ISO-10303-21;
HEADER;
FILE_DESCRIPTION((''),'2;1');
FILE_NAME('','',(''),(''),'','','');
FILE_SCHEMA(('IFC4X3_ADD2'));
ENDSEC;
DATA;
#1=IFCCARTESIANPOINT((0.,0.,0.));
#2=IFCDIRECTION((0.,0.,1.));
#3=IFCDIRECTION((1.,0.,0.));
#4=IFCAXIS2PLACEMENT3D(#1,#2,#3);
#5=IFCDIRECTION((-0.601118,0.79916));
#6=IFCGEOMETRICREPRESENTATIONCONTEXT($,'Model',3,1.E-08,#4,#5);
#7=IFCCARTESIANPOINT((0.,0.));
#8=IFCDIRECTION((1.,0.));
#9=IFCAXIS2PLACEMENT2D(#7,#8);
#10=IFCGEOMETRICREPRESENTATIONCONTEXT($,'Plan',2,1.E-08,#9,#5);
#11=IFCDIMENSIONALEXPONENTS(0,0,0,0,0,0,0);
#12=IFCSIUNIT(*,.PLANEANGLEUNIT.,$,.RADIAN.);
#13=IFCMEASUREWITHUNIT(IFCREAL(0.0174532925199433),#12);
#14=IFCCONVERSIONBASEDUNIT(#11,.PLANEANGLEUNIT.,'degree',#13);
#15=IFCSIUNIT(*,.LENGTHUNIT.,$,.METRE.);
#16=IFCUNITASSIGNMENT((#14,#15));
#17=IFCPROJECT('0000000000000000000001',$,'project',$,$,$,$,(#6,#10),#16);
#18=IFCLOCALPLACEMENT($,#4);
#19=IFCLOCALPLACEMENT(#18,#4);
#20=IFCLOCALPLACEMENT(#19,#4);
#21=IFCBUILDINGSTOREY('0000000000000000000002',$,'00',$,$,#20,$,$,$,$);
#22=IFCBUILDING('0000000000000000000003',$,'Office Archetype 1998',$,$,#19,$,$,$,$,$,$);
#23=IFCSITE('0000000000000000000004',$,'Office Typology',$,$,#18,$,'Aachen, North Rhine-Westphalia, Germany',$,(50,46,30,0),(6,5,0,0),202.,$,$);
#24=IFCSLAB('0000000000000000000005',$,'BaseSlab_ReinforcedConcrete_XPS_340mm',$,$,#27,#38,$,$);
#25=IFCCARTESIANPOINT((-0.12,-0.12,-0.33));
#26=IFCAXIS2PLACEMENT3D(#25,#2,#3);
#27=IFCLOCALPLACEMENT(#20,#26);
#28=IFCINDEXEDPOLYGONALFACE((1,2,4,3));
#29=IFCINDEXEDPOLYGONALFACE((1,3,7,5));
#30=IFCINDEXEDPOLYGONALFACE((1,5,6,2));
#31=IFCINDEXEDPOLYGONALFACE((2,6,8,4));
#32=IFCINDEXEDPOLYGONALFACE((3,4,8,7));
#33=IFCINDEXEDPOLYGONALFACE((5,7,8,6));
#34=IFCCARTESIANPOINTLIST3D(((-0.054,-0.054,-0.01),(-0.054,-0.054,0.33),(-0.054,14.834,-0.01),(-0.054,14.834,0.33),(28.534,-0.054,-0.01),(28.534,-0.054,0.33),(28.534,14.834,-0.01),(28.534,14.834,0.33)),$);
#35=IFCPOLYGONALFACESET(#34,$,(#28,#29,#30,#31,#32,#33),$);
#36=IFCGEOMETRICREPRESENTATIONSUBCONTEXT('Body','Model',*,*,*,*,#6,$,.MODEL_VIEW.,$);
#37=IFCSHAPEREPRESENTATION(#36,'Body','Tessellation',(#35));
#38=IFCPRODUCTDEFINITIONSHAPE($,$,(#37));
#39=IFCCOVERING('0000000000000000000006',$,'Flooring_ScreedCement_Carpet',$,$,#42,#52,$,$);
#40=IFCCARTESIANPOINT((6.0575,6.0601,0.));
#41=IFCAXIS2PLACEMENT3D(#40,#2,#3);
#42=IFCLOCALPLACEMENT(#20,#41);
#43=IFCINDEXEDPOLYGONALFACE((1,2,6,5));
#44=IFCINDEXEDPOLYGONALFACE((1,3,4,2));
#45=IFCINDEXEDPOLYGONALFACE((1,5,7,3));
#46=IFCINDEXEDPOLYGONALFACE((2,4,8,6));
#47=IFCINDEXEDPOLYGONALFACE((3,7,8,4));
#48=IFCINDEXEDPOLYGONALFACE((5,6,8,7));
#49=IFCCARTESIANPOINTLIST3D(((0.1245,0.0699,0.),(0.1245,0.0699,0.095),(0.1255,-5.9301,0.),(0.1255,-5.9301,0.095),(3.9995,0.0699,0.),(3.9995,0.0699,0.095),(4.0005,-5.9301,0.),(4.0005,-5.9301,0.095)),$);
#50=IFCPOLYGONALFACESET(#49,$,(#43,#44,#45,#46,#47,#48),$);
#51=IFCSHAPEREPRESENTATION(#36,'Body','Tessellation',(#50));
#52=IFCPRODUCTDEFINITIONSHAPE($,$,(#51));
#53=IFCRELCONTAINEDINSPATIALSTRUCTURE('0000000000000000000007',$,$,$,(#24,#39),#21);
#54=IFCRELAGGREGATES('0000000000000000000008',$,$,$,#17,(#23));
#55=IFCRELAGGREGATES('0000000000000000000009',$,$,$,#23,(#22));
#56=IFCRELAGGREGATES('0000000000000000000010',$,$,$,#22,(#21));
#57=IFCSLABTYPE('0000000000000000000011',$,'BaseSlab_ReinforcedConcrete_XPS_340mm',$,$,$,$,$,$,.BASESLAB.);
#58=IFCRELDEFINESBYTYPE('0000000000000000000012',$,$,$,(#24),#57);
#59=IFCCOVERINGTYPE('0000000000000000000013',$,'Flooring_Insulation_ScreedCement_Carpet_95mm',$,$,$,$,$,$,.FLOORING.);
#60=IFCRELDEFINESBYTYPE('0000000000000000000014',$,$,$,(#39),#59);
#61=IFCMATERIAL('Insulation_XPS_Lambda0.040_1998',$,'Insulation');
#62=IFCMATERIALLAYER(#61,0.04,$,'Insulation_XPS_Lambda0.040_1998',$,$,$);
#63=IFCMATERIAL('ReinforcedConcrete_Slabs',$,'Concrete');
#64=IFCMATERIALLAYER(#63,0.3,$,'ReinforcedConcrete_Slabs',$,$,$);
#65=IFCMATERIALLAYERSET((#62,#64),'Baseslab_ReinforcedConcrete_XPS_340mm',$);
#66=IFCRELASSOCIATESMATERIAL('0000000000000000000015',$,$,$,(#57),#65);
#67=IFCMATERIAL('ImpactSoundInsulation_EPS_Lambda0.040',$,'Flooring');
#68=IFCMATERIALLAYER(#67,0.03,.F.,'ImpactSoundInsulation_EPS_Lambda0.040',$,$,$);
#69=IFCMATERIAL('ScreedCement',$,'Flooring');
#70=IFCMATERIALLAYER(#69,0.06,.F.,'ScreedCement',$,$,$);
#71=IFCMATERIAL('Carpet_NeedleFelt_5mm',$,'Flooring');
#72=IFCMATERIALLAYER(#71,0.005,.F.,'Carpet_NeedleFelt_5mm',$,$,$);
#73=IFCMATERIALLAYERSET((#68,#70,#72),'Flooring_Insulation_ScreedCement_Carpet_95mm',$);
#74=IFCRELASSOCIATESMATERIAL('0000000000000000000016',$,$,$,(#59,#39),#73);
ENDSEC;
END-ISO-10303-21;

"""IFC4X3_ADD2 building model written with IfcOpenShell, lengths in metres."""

from ifc_helpers import new_model, entity, si_unit, converted_unit, direction, frame, origin_with_axes, origin_2d_with_axis, place, context, subcontext, project, spatial, line, indexed_curve, outline, extrude, material, layer, layer_set, layer_usage, type_object, element, save


model = new_model("IFC4X3_ADD2")

# Units and contexts
model_context = context("Model", 3, precision=1e-08, world=origin_with_axes(), true_north=direction((-0.601118, 0.79916)))
plan_context = context("Plan", 2, precision=1e-08, world=origin_2d_with_axis(), true_north=direction((-0.601118, 0.79916)))
body_context = subcontext(model_context, "Body", "Model", "MODEL_VIEW")
ifc_project = project(units=[converted_unit("PLANEANGLEUNIT", "degree", entity("IfcReal", 0.0174532925199433), si_unit("PLANEANGLEUNIT", "RADIAN"), dimensions=[0, 0, 0, 0, 0, 0, 0]), si_unit("LENGTHUNIT", "METRE")], contexts=[model_context, plan_context])

# Site, building, storey
site_placement = place(None, origin_with_axes())
site = spatial("IfcSite", under=ifc_project, at=site_placement, Name="Office Typology", LongName="Aachen, North Rhine-Westphalia, Germany", RefLatitude=(50, 46, 30, 0), RefLongitude=(6, 5, 0, 0), RefElevation=202.0)
building_placement = place(site_placement, origin_with_axes())
building = spatial("IfcBuilding", under=site, at=building_placement, Name="Office Archetype 1998")
storey_placement = place(building_placement, origin_with_axes())
storey = spatial("IfcBuildingStorey", under=building, at=storey_placement, Name="00")

# Slab
ifc_material_1 = material(Name="Insulation_XPS_Lambda0.040_1998", Category="Insulation")
ifc_layer_1 = layer(ifc_material_1, 0.04, Name="Insulation_XPS_Lambda0.040_1998")
ifc_material_2 = material(Name="ReinforcedConcrete_Slabs", Category="Concrete")
ifc_layer_2 = layer(ifc_material_2, 0.3, Name="ReinforcedConcrete_Slabs")
ifc_layer_set_1 = layer_set([ifc_layer_1, ifc_layer_2], Name="Baseslab_ReinforcedConcrete_XPS_340mm")
slab_type = type_object("IfcSlabType", Name="BaseSlab_ReinforcedConcrete_XPS_340mm", PredefinedType="BASESLAB", material=ifc_layer_set_1)
slab_placement = place(storey_placement, frame((-0.12, -0.12, -0.33), z_axis=(0.0, 0.0, 1.0), x_axis=(1.0, 0.0, 0.0)))
element("IfcSlab", 1, at=slab_placement, inside=storey, type_object=slab_type, Name="BaseSlab_ReinforcedConcrete_XPS_340mm", context=body_context, shape_type="SweptSolid", body=[
    extrude(outline(indexed_curve([(-0.054, -0.054), (28.534, -0.054), (28.534, 14.834), (-0.054, 14.834), (-0.054, -0.054)])), frame((0.0, 0.0, -0.01), z_axis=(0.0, 0.0, 1.0), x_axis=(1.0, 0.0, 0.0)), (0.0, 0.0, 1.0), 0.34),
])

# Covering
ifc_material_3 = material(Name="ImpactSoundInsulation_EPS_Lambda0.040", Category="Flooring")
ifc_layer_3 = layer(ifc_material_3, 0.03, ventilated=False, Name="ImpactSoundInsulation_EPS_Lambda0.040")
ifc_material_4 = material(Name="ScreedCement", Category="Flooring")
ifc_layer_4 = layer(ifc_material_4, 0.06, ventilated=False, Name="ScreedCement")
ifc_material_5 = material(Name="Carpet_NeedleFelt_5mm", Category="Flooring")
ifc_layer_5 = layer(ifc_material_5, 0.005, ventilated=False, Name="Carpet_NeedleFelt_5mm")
ifc_layer_set_2 = layer_set([ifc_layer_3, ifc_layer_4, ifc_layer_5], Name="Flooring_Insulation_ScreedCement_Carpet_95mm")
ifc_layer_usage_1 = layer_usage(ifc_layer_set_2, "AXIS3", "POSITIVE", 0.0)
covering_type_1 = type_object("IfcCoveringType", Name="Flooring_Insulation_ScreedCement_Carpet_95mm", PredefinedType="FLOORING", material=ifc_layer_set_2)
covering_1_placement = place(storey_placement, frame((6.0575, 6.0601, 0.0), z_axis=(0.0, 0.0, 1.0), x_axis=(1.0, 0.0, 0.0)))
element("IfcCovering", 2, at=covering_1_placement, inside=storey, type_object=covering_type_1, material=ifc_layer_usage_1, Name="Flooring_ScreedCement_Carpet", context=body_context, shape_type="SweptSolid", body=[
    extrude(outline(indexed_curve([(0.1255, -5.9301), (0.1245, 0.0699), (3.9995, 0.0699), (4.0005, -5.9301)], segments=[line(1, 2, 3, 4, 1)])), origin_with_axes(), (0.0, 0.0, 1.0), 0.095),
])

save(model, "model.ifc")
